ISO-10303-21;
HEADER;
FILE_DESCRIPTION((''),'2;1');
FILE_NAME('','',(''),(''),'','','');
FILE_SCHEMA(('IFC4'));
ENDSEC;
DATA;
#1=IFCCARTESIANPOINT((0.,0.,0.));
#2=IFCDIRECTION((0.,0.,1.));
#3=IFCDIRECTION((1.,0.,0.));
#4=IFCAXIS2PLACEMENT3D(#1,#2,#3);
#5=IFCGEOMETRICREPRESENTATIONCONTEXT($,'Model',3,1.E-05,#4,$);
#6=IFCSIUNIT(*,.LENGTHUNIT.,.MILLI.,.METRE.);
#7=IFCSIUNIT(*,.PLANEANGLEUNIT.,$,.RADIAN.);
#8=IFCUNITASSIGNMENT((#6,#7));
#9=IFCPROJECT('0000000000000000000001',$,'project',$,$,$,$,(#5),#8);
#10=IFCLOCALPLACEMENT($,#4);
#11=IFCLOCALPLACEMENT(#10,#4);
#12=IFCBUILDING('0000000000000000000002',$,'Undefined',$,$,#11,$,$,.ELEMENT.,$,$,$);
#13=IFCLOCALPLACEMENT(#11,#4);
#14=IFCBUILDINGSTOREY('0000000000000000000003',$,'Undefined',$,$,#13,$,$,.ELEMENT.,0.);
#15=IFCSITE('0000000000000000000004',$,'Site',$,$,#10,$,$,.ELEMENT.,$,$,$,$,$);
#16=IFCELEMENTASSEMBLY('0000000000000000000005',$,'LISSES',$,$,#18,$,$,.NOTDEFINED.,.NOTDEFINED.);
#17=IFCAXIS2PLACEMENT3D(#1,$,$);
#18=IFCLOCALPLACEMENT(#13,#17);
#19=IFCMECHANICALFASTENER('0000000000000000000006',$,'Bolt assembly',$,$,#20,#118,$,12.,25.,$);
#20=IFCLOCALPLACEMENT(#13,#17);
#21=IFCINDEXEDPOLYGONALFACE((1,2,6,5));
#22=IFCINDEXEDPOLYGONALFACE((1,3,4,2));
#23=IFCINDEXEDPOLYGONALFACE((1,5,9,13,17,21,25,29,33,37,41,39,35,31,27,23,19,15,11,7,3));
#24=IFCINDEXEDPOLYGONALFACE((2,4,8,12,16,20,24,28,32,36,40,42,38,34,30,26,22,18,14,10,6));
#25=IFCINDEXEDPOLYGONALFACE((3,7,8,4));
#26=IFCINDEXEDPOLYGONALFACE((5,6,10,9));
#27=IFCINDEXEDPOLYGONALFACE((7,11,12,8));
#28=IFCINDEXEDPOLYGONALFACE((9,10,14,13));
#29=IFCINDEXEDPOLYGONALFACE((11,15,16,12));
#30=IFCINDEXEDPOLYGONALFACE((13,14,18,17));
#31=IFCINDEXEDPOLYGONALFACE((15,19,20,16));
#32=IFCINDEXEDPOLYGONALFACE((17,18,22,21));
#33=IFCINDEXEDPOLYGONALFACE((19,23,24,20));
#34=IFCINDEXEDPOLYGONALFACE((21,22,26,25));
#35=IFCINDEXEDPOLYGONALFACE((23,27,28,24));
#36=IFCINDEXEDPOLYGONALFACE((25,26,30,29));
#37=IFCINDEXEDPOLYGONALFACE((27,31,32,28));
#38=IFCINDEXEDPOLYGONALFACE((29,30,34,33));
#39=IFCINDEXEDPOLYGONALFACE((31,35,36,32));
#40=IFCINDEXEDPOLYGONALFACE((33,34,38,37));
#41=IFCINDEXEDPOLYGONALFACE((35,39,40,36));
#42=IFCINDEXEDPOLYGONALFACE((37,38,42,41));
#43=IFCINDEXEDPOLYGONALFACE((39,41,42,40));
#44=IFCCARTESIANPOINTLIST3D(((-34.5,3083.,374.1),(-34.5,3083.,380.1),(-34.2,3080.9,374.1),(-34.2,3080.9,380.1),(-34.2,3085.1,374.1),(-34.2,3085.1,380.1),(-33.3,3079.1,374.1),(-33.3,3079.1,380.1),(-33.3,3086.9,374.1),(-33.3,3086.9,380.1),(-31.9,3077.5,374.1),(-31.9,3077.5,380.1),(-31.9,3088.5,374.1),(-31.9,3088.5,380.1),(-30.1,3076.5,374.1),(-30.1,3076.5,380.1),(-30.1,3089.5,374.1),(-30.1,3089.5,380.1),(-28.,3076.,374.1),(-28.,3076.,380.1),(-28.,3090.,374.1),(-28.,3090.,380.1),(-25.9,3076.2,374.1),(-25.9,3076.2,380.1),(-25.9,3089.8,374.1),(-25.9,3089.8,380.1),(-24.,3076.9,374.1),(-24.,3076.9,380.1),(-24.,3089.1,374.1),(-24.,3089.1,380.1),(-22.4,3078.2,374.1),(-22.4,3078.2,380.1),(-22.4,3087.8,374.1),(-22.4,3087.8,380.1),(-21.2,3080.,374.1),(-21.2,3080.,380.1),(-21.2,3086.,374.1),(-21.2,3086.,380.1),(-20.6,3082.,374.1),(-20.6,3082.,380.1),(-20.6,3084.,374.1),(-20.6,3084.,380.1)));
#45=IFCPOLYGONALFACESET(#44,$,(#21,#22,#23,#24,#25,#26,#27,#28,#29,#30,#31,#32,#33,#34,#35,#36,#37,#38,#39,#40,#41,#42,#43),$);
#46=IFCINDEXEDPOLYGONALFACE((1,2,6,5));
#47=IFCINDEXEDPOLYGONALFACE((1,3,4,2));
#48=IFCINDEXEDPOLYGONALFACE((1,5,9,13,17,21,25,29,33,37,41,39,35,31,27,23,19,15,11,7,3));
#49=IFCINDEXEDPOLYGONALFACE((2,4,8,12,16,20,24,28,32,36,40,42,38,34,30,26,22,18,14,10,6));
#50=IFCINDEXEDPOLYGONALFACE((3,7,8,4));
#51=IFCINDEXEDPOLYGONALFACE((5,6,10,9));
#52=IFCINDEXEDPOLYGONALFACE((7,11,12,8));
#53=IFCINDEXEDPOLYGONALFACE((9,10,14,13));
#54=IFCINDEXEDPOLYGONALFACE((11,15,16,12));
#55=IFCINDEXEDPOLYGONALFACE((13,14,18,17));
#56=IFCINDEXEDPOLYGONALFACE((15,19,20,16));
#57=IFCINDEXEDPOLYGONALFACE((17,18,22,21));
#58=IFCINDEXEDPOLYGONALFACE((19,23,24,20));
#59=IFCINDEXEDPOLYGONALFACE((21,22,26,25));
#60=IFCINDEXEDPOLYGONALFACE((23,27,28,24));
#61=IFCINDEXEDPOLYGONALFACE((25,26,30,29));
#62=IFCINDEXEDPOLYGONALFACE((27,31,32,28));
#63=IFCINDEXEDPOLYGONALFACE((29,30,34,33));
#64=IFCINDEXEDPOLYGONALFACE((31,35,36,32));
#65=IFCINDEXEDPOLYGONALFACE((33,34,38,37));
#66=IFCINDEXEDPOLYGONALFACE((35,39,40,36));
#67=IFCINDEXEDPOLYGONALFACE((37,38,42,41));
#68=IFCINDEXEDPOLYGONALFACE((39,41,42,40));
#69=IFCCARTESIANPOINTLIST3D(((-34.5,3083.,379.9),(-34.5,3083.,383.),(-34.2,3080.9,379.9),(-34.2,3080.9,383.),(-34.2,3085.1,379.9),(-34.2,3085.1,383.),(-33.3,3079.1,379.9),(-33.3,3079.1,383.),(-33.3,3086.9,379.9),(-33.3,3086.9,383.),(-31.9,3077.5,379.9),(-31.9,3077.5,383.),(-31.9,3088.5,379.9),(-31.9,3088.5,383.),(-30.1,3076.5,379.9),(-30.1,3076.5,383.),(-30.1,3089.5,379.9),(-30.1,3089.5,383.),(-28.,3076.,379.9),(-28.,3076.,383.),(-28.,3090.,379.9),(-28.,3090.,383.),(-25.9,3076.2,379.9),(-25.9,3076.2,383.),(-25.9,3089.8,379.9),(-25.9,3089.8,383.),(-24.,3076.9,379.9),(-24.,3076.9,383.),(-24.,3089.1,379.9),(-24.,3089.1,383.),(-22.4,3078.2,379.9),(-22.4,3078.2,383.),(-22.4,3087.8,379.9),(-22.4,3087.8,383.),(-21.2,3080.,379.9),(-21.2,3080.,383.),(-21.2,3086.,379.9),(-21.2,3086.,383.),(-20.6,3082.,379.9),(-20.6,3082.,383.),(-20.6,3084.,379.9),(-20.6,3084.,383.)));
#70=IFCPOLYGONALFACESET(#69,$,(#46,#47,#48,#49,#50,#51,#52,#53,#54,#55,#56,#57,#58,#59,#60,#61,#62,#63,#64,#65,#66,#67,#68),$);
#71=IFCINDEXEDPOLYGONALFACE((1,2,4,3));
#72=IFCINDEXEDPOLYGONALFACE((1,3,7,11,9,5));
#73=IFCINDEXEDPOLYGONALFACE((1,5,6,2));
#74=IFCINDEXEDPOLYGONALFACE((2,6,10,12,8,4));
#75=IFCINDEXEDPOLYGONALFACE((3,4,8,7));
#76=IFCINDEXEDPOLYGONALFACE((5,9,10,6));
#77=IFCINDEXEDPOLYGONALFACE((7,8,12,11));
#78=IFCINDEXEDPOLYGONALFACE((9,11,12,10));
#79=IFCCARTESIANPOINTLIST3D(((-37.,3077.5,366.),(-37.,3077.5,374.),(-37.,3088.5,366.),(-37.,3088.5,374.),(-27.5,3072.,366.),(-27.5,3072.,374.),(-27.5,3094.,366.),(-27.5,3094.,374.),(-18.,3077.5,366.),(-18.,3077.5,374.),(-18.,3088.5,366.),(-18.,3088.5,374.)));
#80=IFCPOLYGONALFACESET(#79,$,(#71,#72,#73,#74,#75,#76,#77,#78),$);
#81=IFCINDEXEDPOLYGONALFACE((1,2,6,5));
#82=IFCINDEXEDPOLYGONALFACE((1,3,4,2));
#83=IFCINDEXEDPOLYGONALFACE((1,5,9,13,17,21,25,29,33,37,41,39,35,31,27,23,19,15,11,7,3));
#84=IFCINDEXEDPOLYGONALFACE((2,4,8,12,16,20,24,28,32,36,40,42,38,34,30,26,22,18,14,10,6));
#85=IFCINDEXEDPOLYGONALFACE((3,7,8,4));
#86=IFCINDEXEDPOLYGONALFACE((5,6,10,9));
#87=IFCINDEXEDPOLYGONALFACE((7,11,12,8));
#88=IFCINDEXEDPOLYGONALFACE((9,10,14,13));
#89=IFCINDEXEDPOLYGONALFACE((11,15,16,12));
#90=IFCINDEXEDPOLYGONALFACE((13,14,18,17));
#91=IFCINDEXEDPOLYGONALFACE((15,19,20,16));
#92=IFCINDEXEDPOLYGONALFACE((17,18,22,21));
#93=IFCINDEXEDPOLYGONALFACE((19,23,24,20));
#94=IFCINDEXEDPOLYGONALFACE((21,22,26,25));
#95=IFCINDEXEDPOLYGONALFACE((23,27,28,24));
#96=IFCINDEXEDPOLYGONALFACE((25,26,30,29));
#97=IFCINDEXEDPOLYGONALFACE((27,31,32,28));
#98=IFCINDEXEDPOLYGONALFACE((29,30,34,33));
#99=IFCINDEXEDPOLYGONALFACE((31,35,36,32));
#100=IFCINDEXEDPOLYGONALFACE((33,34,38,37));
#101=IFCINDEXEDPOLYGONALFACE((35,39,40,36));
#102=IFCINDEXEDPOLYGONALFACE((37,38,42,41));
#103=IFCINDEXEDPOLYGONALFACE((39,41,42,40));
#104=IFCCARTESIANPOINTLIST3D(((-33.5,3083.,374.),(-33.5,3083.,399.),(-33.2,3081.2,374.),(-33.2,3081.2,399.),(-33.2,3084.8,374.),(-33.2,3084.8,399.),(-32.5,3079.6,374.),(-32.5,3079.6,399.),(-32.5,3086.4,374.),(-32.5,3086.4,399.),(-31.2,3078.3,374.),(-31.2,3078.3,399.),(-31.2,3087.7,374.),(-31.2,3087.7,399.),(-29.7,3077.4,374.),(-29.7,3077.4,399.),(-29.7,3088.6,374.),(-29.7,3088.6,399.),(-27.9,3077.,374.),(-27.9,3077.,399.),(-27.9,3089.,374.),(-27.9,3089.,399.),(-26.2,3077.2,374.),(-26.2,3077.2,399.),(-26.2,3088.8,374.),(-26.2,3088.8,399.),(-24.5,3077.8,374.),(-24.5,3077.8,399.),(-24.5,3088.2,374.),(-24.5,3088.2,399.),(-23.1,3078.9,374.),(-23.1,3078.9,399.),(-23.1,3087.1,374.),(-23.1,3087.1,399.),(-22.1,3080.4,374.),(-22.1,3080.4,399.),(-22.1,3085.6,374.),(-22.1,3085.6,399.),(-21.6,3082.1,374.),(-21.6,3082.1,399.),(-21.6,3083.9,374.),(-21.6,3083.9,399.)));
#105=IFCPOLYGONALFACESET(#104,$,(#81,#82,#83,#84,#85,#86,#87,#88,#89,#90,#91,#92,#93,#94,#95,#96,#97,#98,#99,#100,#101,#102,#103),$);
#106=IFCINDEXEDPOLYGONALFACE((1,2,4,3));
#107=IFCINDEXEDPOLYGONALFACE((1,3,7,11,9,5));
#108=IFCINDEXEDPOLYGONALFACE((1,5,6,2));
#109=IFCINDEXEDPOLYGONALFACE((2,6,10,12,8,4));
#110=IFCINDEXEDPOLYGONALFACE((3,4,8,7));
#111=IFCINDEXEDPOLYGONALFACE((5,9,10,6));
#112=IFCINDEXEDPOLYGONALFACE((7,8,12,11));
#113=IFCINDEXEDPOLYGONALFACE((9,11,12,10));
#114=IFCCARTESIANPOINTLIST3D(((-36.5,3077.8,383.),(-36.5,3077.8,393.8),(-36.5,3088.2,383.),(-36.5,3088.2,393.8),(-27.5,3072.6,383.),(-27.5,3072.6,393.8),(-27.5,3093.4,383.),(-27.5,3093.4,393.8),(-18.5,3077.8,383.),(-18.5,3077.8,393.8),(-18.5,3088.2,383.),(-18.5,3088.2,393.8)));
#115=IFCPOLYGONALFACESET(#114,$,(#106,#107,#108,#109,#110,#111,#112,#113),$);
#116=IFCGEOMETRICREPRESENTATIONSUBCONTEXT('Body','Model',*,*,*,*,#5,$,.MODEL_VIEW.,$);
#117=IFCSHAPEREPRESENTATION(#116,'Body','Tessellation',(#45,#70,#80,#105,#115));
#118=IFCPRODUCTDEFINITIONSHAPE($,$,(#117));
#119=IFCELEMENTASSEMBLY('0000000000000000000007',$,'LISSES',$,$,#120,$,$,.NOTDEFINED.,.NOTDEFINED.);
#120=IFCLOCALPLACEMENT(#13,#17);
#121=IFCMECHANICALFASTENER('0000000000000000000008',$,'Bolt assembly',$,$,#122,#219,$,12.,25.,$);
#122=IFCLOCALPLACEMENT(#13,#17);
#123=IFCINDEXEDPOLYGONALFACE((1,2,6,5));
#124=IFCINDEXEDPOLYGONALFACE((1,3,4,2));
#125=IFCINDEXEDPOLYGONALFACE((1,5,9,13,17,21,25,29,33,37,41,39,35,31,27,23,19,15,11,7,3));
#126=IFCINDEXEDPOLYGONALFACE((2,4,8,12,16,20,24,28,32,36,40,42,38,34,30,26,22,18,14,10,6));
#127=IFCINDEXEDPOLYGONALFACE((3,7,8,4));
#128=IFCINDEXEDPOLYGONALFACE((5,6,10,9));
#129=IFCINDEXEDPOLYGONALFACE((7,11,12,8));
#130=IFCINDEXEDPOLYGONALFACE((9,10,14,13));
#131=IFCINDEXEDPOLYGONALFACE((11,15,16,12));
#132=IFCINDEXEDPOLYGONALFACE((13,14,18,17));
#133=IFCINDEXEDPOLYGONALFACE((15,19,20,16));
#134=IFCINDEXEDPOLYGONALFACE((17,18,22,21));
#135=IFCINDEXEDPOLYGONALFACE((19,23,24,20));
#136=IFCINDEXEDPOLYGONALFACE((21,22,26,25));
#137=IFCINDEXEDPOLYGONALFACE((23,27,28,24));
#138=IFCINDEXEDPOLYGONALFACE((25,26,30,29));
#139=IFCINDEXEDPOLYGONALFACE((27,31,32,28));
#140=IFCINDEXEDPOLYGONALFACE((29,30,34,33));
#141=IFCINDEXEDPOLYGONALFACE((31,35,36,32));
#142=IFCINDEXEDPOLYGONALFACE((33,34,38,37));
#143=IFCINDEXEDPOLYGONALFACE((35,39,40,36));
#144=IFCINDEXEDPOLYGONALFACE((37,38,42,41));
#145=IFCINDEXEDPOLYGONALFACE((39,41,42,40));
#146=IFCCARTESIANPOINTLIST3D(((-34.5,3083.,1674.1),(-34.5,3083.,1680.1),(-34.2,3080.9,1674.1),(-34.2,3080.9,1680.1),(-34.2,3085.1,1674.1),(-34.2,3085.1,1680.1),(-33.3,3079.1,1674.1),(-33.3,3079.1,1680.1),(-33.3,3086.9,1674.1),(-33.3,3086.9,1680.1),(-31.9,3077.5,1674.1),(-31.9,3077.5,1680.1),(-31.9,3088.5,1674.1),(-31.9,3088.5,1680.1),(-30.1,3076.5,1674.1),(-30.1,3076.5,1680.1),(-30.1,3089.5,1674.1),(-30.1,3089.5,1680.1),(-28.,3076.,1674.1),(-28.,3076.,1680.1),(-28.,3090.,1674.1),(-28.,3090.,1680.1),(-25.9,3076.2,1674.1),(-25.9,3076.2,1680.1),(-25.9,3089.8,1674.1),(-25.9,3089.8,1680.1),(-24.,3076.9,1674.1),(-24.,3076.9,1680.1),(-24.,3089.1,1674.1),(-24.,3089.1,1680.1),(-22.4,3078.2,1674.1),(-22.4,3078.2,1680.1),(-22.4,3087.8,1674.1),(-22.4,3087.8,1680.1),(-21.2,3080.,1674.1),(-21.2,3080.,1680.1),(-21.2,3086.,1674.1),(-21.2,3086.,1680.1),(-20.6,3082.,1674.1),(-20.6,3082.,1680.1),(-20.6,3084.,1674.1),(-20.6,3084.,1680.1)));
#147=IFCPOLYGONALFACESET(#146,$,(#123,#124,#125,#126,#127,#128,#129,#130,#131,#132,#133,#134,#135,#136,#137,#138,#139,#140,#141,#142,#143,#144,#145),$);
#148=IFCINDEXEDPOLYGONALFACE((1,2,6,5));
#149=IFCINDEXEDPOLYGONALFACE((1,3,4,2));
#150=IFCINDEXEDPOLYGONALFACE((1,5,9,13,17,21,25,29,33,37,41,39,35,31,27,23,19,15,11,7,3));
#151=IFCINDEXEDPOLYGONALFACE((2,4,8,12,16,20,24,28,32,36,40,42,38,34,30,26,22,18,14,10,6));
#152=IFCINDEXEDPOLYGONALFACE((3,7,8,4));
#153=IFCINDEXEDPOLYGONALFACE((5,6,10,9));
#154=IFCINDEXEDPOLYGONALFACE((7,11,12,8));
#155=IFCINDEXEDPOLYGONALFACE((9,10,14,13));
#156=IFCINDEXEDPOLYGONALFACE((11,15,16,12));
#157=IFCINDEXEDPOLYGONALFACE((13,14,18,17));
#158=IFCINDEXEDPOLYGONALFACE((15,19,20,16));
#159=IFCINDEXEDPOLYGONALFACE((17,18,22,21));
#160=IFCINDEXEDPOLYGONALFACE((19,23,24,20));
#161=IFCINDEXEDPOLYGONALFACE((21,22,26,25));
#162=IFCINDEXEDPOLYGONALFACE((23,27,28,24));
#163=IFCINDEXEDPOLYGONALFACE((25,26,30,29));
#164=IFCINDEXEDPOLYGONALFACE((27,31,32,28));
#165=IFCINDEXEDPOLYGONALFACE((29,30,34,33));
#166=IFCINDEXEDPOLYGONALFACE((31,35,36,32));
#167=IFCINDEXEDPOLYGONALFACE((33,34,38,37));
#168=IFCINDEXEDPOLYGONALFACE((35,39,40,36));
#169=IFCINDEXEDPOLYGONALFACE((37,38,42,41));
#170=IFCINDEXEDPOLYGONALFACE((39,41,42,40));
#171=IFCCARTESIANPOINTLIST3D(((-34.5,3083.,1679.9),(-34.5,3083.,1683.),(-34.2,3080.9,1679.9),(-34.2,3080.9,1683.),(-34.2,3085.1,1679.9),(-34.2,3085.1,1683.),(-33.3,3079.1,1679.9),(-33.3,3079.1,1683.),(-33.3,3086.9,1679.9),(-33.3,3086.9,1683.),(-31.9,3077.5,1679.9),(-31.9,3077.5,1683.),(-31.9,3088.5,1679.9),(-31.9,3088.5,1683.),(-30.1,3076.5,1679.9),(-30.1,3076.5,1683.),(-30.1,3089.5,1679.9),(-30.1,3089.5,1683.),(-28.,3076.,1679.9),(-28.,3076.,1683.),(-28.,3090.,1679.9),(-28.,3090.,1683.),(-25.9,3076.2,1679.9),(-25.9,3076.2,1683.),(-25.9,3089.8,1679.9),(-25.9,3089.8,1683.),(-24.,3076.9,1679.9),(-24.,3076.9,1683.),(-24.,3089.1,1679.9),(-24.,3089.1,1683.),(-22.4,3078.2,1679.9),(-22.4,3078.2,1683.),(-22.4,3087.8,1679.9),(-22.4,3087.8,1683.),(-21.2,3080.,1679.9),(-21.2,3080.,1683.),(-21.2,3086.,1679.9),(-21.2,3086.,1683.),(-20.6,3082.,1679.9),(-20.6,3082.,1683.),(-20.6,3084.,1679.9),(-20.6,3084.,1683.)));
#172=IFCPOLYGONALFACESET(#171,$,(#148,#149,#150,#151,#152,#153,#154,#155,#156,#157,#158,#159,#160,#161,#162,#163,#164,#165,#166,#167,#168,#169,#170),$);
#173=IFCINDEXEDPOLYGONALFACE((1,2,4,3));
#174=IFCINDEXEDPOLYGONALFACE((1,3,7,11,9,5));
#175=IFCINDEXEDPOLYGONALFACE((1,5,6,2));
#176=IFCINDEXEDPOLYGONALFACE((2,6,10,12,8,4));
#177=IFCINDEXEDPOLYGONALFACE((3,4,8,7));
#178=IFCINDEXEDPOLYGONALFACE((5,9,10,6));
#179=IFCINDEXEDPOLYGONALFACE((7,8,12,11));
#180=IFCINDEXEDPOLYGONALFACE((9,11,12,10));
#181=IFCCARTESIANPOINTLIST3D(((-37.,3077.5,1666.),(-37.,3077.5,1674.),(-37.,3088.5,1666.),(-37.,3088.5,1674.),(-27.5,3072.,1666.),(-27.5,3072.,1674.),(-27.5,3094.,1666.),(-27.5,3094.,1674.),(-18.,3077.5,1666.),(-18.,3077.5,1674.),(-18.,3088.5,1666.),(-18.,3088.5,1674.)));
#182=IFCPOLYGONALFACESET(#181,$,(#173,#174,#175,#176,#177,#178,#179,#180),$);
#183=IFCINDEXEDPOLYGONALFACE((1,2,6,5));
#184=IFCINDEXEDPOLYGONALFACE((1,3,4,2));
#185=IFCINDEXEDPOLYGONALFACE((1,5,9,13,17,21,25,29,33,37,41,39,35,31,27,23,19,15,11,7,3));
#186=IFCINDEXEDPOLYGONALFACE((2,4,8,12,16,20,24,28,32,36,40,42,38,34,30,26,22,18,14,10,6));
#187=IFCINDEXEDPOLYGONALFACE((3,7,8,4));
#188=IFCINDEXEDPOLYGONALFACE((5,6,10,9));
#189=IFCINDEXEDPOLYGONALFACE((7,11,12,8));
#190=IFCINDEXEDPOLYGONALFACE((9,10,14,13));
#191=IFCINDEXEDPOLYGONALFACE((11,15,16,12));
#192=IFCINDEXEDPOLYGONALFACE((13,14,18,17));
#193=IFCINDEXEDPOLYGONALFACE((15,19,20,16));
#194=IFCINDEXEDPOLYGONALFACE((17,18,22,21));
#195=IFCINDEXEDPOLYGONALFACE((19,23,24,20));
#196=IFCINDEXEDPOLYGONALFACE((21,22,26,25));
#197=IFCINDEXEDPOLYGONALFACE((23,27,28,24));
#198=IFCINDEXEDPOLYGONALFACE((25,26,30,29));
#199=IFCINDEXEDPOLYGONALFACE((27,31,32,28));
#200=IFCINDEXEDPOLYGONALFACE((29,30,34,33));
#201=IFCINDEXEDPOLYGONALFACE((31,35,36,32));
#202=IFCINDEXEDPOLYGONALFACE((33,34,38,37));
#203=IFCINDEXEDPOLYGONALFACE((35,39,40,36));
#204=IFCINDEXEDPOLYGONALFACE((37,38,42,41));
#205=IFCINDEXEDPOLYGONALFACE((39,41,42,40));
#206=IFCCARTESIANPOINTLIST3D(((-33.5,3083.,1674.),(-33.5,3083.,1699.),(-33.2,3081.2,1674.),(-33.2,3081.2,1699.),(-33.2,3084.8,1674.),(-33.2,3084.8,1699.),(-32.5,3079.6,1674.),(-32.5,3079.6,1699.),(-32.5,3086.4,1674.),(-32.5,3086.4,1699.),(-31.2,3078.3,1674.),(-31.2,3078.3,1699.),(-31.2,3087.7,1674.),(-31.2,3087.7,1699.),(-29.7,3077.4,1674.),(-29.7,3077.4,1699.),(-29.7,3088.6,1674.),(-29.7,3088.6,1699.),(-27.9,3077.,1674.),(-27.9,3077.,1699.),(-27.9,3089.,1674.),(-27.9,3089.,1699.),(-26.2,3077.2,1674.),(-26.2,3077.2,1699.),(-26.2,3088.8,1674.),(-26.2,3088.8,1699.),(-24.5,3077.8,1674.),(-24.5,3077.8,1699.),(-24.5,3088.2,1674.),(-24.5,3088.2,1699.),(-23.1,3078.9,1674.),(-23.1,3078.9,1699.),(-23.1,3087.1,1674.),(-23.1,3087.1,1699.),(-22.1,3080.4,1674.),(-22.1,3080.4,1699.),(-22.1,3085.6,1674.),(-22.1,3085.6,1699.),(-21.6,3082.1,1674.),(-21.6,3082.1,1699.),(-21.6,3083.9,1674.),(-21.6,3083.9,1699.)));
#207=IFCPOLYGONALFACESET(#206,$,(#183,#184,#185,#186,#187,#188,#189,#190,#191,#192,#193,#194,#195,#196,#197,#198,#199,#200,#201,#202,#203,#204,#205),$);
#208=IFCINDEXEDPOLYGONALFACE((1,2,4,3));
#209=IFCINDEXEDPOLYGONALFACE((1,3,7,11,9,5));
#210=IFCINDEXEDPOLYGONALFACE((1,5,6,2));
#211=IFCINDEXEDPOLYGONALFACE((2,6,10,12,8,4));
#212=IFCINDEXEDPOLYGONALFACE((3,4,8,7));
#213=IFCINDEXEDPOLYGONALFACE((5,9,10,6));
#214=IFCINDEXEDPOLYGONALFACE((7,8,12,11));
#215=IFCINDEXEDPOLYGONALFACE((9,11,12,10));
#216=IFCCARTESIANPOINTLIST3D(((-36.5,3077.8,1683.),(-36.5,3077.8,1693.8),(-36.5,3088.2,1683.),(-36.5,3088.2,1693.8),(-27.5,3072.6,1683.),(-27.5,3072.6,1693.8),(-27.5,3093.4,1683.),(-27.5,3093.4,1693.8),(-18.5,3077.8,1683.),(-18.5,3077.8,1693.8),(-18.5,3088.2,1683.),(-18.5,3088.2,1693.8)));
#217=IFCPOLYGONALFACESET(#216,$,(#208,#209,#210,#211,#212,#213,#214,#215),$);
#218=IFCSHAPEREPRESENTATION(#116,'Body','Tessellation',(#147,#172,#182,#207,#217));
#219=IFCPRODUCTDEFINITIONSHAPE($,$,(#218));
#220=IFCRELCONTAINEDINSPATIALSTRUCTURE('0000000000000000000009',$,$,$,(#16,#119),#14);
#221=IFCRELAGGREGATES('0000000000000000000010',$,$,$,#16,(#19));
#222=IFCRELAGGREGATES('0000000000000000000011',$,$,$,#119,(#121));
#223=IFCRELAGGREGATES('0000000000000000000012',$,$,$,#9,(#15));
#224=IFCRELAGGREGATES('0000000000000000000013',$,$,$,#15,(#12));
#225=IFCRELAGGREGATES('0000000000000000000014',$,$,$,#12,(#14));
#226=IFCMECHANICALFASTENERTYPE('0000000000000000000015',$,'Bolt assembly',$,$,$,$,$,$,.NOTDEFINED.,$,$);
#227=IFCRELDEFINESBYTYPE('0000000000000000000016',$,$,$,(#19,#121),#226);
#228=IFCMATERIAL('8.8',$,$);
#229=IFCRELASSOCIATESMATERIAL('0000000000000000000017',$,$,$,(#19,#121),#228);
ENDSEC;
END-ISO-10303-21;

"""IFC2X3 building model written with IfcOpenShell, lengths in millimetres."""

from ifc_helpers import new_model, si_unit, frame, origin_with_axes, origin_2d_with_axis, place, context, subcontext, project, spatial, polyline, circle, outline, extrude, source, transform, mapped, material, type_object, element, aggregate, save


model = new_model("IFC2X3")

# Units and contexts
model_context = context("Model", 3, precision=1e-05, world=origin_with_axes())
body_context = subcontext(model_context, "Body", "Model", "MODEL_VIEW")
ifc_project = project(units=[si_unit("LENGTHUNIT", "METRE", prefix="MILLI"), si_unit("PLANEANGLEUNIT", "RADIAN")], contexts=[model_context])

# Site, building, storey
site_placement = place(None, origin_with_axes())
site = spatial("IfcSite", under=ifc_project, at=site_placement, Name="Site", CompositionType="ELEMENT")
building_placement = place(site_placement, origin_with_axes())
building = spatial("IfcBuilding", under=site, at=building_placement, Name="Undefined", CompositionType="ELEMENT")
storey_placement = place(building_placement, origin_with_axes())
storey = spatial("IfcBuildingStorey", under=building, at=storey_placement, Name="Undefined", CompositionType="ELEMENT", Elevation=0.0)

# Shared definitions
mechanical_fastener_type = type_object("IfcMechanicalFastenerType", Name="Bolt assembly")
ifc_material_1 = material(Name="8.8")

# Element assemblies, mechanical fasteners
assembly_1_placement = place(storey_placement, origin_with_axes())
assembly_1 = element("IfcElementAssembly", 1, at=assembly_1_placement, inside=storey, Name="LISSES", AssemblyPlace="NOTDEFINED", PredefinedType="NOTDEFINED")
shared_shape_1 = source(origin_with_axes(), body_context, "Body", "SweptSolid", [
    extrude(circle(Radius=7.0, at=origin_2d_with_axis()), frame((0.0, -5.9, 0.0), z_axis=(0.0, 1.0, 0.0), x_axis=(1.0, 0.0, 0.0)), (0.0, 0.0, 1.0), 6.0),
    extrude(circle(Radius=7.0, at=origin_2d_with_axis()), frame((0.0, -0.1, 0.0), z_axis=(0.0, 1.0, 0.0), x_axis=(1.0, 0.0, 0.0)), (0.0, 0.0, 1.0), 3.1),
    extrude(outline(polyline([(9.5, -5.5), (9.5, 5.5), (0.0, 11.0), (-9.5, 5.5), (-9.5, -5.5), (0.0, -11.0), (9.5, -5.5)])), frame((0.0, -14.0, 0.0), z_axis=(0.0, 1.0, 0.0), x_axis=(1.0, 0.0, 0.0)), (0.0, 0.0, 1.0), 8.0),
    extrude(circle(Radius=6.0, at=origin_2d_with_axis()), frame((0.0, -6.0, 0.0), z_axis=(0.0, 1.0, 0.0), x_axis=(1.0, 0.0, 0.0)), (0.0, 0.0, 1.0), 25.0),
    extrude(outline(polyline([(9.0, -5.2), (9.0, 5.2), (0.0, 10.4), (-9.0, 5.2), (-9.0, -5.2), (0.0, -10.4), (9.0, -5.2)])), frame((0.0, 3.0, 0.0), z_axis=(0.0, 1.0, 0.0), x_axis=(1.0, 0.0, 0.0)), (0.0, 0.0, 1.0), 10.8),
])
mechanical_fastener_1_placement = place(assembly_1_placement, frame((-27.5, 3083.0, 380.0), z_axis=(0.0, 1.0, 0.0), x_axis=(-1.0, 0.0, 0.0)))
mechanical_fastener_1 = element("IfcMechanicalFastener", 2, at=mechanical_fastener_1_placement, type_object=mechanical_fastener_type, material=ifc_material_1, Name="Bolt assembly", NominalDiameter=12.0, NominalLength=25.0, context=body_context, shape_type="MappedRepresentation", body=[
    mapped(shared_shape_1, transform((0.0, 0.0, 0.0))),
])
aggregate(assembly_1, [mechanical_fastener_1])
assembly_2_placement = place(storey_placement, origin_with_axes())
assembly_2 = element("IfcElementAssembly", 3, at=assembly_2_placement, inside=storey, Name="LISSES", AssemblyPlace="NOTDEFINED", PredefinedType="NOTDEFINED")
mechanical_fastener_2_placement = place(assembly_2_placement, frame((-27.5, 3083.0, 1680.0), z_axis=(0.0, 1.0, 0.0), x_axis=(-1.0, 0.0, 0.0)))
mechanical_fastener_2 = element("IfcMechanicalFastener", 4, at=mechanical_fastener_2_placement, type_object=mechanical_fastener_type, material=ifc_material_1, Name="Bolt assembly", NominalDiameter=12.0, NominalLength=25.0, context=body_context, shape_type="MappedRepresentation", body=[
    mapped(shared_shape_1, transform((0.0, 0.0, 0.0))),
])
aggregate(assembly_2, [mechanical_fastener_2])

save(model, "model.ifc")
